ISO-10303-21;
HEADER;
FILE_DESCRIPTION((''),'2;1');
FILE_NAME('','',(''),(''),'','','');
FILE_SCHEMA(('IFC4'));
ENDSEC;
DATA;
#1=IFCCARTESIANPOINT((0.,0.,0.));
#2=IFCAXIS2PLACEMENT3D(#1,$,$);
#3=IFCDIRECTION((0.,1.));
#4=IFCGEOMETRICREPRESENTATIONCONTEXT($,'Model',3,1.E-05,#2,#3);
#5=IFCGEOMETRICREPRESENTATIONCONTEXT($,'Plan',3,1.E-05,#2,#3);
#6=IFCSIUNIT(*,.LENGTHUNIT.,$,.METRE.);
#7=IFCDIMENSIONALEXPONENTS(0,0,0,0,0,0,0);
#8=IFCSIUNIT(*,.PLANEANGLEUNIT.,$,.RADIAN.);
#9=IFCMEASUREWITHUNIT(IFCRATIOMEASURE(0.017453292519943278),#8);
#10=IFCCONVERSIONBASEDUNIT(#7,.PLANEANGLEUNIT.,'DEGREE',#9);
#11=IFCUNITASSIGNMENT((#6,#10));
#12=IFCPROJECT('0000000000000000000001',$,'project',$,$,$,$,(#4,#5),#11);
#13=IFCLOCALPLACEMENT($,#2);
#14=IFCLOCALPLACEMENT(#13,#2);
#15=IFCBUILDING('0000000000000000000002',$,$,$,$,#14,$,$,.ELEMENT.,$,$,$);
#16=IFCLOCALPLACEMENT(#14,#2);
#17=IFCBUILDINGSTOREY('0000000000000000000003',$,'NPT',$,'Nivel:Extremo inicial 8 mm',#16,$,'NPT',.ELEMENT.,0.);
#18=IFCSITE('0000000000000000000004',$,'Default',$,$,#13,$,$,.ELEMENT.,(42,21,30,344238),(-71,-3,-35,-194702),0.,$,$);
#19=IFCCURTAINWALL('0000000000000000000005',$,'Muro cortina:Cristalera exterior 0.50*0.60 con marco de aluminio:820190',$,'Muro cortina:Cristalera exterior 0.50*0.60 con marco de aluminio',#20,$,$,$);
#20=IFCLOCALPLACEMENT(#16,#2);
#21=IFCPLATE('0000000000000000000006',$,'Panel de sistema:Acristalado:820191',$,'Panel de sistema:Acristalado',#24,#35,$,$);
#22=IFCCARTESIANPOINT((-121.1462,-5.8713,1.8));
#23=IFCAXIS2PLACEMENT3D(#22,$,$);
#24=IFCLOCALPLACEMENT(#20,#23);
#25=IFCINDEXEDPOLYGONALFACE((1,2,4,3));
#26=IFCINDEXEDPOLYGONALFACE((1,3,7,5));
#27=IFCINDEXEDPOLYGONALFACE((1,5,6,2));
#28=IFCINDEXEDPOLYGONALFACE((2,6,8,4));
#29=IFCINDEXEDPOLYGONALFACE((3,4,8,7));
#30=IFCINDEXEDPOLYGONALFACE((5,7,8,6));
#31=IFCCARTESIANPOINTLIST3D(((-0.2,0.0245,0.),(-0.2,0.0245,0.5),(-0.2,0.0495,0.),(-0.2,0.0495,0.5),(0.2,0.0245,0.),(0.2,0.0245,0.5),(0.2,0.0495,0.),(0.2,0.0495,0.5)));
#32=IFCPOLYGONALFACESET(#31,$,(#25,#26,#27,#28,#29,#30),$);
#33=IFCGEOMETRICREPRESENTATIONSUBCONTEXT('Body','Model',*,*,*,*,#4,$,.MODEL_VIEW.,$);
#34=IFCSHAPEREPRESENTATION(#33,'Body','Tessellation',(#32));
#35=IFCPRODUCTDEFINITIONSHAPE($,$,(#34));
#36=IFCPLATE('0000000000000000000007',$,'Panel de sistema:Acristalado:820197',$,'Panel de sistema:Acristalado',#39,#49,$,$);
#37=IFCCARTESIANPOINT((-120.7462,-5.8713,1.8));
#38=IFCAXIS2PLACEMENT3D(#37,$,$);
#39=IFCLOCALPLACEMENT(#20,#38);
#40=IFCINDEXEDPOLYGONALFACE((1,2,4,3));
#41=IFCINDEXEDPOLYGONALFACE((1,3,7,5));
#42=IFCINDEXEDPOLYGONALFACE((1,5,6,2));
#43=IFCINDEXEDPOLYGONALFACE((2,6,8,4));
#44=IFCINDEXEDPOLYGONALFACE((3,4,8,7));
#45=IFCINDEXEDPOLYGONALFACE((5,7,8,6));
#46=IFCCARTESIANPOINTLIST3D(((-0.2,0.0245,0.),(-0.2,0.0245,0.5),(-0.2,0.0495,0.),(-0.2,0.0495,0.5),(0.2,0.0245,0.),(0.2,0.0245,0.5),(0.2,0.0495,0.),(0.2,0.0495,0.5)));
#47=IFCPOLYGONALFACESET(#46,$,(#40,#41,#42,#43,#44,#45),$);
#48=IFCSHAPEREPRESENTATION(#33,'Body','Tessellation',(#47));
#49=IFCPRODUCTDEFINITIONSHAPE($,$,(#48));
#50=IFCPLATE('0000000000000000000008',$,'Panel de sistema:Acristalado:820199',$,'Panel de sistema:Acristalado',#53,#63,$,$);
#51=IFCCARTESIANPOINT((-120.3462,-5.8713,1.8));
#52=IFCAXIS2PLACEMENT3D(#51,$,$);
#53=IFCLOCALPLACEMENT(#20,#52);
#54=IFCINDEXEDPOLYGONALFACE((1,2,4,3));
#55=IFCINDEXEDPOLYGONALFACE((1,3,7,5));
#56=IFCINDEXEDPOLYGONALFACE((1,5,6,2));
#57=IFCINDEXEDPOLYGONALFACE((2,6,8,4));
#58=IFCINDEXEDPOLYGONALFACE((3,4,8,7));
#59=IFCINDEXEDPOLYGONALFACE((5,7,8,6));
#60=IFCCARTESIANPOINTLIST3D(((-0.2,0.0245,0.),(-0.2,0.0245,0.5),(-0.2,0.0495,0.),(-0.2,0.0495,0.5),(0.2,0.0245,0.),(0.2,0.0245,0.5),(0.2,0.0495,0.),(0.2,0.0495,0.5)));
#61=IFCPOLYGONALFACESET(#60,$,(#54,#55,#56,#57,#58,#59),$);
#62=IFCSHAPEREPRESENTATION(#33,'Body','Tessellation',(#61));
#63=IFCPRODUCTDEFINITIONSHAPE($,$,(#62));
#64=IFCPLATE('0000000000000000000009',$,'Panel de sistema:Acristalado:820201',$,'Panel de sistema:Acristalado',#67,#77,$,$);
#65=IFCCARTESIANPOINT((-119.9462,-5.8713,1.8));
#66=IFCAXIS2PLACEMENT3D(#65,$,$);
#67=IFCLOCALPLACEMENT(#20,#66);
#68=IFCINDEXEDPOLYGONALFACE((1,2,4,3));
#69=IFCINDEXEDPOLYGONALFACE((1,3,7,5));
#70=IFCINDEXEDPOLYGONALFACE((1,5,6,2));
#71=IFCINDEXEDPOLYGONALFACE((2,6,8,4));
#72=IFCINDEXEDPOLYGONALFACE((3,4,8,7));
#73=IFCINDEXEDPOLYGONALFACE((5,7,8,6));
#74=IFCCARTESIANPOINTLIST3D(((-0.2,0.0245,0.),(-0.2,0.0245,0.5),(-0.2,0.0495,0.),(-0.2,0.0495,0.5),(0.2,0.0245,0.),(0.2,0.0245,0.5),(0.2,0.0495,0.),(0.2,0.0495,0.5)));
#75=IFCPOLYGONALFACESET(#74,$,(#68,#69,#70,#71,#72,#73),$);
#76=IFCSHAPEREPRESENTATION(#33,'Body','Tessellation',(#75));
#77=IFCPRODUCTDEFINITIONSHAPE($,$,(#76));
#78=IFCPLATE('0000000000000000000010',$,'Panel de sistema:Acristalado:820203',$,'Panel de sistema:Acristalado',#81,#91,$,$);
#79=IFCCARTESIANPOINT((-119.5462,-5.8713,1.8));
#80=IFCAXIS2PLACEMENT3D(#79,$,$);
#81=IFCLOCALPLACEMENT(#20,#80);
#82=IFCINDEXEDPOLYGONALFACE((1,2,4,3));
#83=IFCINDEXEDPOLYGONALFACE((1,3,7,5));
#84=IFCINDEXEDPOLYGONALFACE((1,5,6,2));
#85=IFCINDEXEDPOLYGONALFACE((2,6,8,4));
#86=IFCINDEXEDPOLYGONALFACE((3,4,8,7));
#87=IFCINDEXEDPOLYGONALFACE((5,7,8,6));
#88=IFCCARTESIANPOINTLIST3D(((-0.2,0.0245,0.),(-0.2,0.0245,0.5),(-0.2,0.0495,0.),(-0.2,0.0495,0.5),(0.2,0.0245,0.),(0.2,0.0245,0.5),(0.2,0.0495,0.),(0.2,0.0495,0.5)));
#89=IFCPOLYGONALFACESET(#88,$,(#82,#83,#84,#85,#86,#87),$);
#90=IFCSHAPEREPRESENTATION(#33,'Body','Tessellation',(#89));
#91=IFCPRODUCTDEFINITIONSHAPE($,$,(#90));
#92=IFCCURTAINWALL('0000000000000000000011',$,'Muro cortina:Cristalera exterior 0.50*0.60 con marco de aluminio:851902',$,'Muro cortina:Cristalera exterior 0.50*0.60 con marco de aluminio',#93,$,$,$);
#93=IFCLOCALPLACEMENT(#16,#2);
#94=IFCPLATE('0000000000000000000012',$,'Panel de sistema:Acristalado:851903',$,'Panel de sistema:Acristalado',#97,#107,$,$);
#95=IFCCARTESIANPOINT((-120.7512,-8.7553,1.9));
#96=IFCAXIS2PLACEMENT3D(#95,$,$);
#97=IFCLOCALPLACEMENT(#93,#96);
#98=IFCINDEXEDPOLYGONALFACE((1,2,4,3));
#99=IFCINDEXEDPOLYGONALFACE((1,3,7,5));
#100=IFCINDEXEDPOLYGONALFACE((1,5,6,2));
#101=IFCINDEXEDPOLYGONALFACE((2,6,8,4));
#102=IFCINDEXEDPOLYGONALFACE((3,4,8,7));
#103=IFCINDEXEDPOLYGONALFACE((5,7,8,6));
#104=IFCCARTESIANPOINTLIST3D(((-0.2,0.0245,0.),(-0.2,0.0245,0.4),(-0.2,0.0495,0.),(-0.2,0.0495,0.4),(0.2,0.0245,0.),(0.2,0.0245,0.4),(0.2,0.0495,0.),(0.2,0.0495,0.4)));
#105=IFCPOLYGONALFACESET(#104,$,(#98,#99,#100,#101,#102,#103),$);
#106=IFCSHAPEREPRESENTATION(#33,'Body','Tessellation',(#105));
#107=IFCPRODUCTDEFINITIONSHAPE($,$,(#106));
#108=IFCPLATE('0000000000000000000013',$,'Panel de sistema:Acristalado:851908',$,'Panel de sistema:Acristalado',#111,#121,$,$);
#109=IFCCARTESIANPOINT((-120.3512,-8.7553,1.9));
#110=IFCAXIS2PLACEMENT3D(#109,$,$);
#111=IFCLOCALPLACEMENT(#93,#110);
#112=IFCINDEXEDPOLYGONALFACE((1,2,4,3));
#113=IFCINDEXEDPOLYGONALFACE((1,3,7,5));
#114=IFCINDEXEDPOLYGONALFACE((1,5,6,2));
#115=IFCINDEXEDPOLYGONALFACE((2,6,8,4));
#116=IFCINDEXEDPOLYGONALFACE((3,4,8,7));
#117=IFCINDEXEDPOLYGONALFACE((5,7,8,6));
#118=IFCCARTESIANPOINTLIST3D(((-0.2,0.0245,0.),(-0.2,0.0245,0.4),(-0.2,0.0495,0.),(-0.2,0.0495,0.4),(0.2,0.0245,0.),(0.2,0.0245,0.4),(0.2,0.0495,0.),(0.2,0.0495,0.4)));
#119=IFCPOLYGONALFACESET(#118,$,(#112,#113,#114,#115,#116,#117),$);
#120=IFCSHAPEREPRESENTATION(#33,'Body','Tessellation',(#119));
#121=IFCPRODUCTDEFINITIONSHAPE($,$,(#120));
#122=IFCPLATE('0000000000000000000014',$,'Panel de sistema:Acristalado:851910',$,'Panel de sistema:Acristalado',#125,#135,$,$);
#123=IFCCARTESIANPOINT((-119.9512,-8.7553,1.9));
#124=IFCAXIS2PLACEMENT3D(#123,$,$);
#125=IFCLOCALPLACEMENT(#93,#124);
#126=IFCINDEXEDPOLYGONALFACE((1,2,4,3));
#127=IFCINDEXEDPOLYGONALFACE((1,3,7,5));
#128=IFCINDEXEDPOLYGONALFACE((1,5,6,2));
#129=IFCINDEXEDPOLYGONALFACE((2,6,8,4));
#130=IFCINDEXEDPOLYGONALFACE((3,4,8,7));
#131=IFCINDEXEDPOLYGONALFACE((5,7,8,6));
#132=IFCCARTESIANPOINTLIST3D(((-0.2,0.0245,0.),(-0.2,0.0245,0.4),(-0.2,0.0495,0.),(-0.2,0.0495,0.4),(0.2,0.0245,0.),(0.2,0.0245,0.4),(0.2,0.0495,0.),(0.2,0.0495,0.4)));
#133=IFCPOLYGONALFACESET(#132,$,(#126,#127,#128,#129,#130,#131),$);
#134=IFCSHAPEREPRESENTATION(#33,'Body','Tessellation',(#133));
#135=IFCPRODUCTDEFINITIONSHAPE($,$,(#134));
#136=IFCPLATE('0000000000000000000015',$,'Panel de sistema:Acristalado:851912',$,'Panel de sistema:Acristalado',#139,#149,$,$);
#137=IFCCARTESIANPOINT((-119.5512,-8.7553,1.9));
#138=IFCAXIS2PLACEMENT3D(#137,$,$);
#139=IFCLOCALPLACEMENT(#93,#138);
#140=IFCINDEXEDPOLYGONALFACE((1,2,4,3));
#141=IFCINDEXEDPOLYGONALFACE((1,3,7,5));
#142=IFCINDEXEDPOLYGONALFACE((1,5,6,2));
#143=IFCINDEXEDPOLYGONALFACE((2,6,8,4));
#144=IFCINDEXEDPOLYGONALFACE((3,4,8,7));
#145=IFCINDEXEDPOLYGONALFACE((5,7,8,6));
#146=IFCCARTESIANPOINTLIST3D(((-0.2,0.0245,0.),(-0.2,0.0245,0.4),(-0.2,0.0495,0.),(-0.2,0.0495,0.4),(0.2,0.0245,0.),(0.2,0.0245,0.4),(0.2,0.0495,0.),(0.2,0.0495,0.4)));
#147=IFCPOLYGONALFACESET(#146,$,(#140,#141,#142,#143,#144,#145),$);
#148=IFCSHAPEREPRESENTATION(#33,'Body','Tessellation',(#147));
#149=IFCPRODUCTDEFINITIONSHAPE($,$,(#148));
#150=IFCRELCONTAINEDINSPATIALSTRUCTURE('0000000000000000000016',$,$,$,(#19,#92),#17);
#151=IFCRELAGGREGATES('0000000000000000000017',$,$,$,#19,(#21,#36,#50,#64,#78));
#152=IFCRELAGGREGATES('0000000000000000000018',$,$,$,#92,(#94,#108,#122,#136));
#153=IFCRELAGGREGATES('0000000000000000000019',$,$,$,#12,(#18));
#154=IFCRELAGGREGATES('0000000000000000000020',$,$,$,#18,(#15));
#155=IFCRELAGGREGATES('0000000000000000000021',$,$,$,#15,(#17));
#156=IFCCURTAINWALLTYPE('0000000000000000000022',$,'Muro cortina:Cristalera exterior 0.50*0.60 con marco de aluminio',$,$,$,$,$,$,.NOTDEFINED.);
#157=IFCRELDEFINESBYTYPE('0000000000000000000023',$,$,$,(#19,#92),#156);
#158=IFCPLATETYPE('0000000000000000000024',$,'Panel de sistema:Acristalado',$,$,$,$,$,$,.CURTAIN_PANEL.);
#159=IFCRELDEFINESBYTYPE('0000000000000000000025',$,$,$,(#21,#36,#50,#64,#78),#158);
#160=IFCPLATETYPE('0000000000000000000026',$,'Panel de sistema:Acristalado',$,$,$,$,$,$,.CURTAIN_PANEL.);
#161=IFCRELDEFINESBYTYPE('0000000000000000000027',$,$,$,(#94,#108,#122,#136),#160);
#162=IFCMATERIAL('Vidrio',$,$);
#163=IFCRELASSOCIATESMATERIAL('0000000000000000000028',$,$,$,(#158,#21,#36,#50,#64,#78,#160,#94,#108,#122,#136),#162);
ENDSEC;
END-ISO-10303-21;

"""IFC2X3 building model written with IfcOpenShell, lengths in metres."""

from ifc_helpers import new_model, entity, si_unit, converted_unit, direction, frame, origin, origin_2d_with_axis, place, context, subcontext, project, spatial, rectangle, extrude, source, transform, mapped, material, type_object, type_shapes, element, aggregate, save


model = new_model("IFC2X3")

# Units and contexts
model_context = context("Model", 3, precision=1e-05, world=origin(), true_north=direction((0.0, 1.0)))
plan_context = context("Plan", 3, precision=1e-05, world=origin(), true_north=direction((0.0, 1.0)))
body_context = subcontext(model_context, "Body", "Model", "MODEL_VIEW")
ifc_project = project(units=[si_unit("LENGTHUNIT", "METRE"), converted_unit("PLANEANGLEUNIT", "DEGREE", entity("IfcRatioMeasure", 0.017453292519943278), si_unit("PLANEANGLEUNIT", "RADIAN"), dimensions=[0, 0, 0, 0, 0, 0, 0])], contexts=[model_context, plan_context])

# Site, building, storey
site_placement = place(None, origin())
site = spatial("IfcSite", under=ifc_project, at=site_placement, Name="Default", CompositionType="ELEMENT", RefLatitude=(42, 21, 30, 344238), RefLongitude=(-71, -3, -35, -194702), RefElevation=0.0)
building_placement = place(site_placement, origin())
building = spatial("IfcBuilding", under=site, at=building_placement, CompositionType="ELEMENT")
storey_placement = place(building_placement, origin())
storey = spatial("IfcBuildingStorey", under=building, at=storey_placement, Name="NPT", ObjectType="Nivel:Extremo inicial 8 mm", LongName="NPT", CompositionType="ELEMENT", Elevation=0.0)

# Curtain walls, plates
curtain_wall_type = type_object("IfcCurtainWallType", Name="Muro cortina:Cristalera exterior 0.50*0.60 con marco de aluminio", PredefinedType="NOTDEFINED")
curtain_wall_1_placement = place(storey_placement, origin())
curtain_wall_1 = element("IfcCurtainWall", 1, at=curtain_wall_1_placement, inside=storey, type_object=curtain_wall_type, Name="Muro cortina:Cristalera exterior 0.50*0.60 con marco de aluminio:820190", ObjectType="Muro cortina:Cristalera exterior 0.50*0.60 con marco de aluminio")
ifc_material_1 = material(Name="Vidrio")
plate_type_1 = type_object("IfcPlateType", Name="Panel de sistema:Acristalado", PredefinedType="CURTAIN_PANEL", material=ifc_material_1)
shared_shape_1 = source(origin(), body_context, "Body", "SweptSolid", [
    extrude(rectangle(XDim=0.025, YDim=0.4, at=origin_2d_with_axis()), frame((0.0, 0.037, 0.0), z_axis=(0.0, 0.0, 1.0), x_axis=(0.0, 1.0, 0.0)), (0.0, 0.0, 1.0), 0.5),
])
type_shapes(plate_type_1, [shared_shape_1])
plate_1_placement = place(curtain_wall_1_placement, frame((-121.1462, -5.8713, 1.8)))
plate_1 = element("IfcPlate", 2, at=plate_1_placement, type_object=plate_type_1, material=ifc_material_1, Name="Panel de sistema:Acristalado:820191", ObjectType="Panel de sistema:Acristalado", context=body_context, shape_type="MappedRepresentation", body=[
    mapped(shared_shape_1, transform((0.0, 0.0, 0.0), scale=1.0)),
])
plate_2_placement = place(curtain_wall_1_placement, frame((-120.7462, -5.8713, 1.8)))
plate_2 = element("IfcPlate", 3, at=plate_2_placement, type_object=plate_type_1, material=ifc_material_1, Name="Panel de sistema:Acristalado:820197", ObjectType="Panel de sistema:Acristalado", context=body_context, shape_type="MappedRepresentation", body=[
    mapped(shared_shape_1, transform((0.0, 0.0, 0.0), scale=1.0)),
])
plate_3_placement = place(curtain_wall_1_placement, frame((-120.3462, -5.8713, 1.8)))
plate_3 = element("IfcPlate", 4, at=plate_3_placement, type_object=plate_type_1, material=ifc_material_1, Name="Panel de sistema:Acristalado:820199", ObjectType="Panel de sistema:Acristalado", context=body_context, shape_type="MappedRepresentation", body=[
    mapped(shared_shape_1, transform((0.0, 0.0, 0.0), scale=1.0)),
])
plate_4_placement = place(curtain_wall_1_placement, frame((-119.9462, -5.8713, 1.8)))
plate_4 = element("IfcPlate", 5, at=plate_4_placement, type_object=plate_type_1, material=ifc_material_1, Name="Panel de sistema:Acristalado:820201", ObjectType="Panel de sistema:Acristalado", context=body_context, shape_type="MappedRepresentation", body=[
    mapped(shared_shape_1, transform((0.0, 0.0, 0.0), scale=1.0)),
])
plate_5_placement = place(curtain_wall_1_placement, frame((-119.5462, -5.8713, 1.8)))
plate_5 = element("IfcPlate", 6, at=plate_5_placement, type_object=plate_type_1, material=ifc_material_1, Name="Panel de sistema:Acristalado:820203", ObjectType="Panel de sistema:Acristalado", context=body_context, shape_type="MappedRepresentation", body=[
    mapped(shared_shape_1, transform((0.0, 0.0, 0.0), scale=1.0)),
])
aggregate(curtain_wall_1, [plate_1, plate_2, plate_3, plate_4, plate_5])
curtain_wall_2_placement = place(storey_placement, origin())
curtain_wall_2 = element("IfcCurtainWall", 7, at=curtain_wall_2_placement, inside=storey, type_object=curtain_wall_type, Name="Muro cortina:Cristalera exterior 0.50*0.60 con marco de aluminio:851902", ObjectType="Muro cortina:Cristalera exterior 0.50*0.60 con marco de aluminio")
plate_type_2 = type_object("IfcPlateType", Name="Panel de sistema:Acristalado", PredefinedType="CURTAIN_PANEL", material=ifc_material_1)
shared_shape_2 = source(origin(), body_context, "Body", "SweptSolid", [
    extrude(rectangle(XDim=0.025, YDim=0.4, at=origin_2d_with_axis()), frame((0.0, 0.037, 0.0), z_axis=(0.0, 0.0, 1.0), x_axis=(0.0, 1.0, 0.0)), (0.0, 0.0, 1.0), 0.4),
])
type_shapes(plate_type_2, [shared_shape_2])
plate_6_placement = place(curtain_wall_2_placement, frame((-120.7512, -8.7553, 1.9)))
plate_6 = element("IfcPlate", 8, at=plate_6_placement, type_object=plate_type_2, material=ifc_material_1, Name="Panel de sistema:Acristalado:851903", ObjectType="Panel de sistema:Acristalado", context=body_context, shape_type="MappedRepresentation", body=[
    mapped(shared_shape_2, transform((0.0, 0.0, 0.0), scale=1.0)),
])
plate_7_placement = place(curtain_wall_2_placement, frame((-120.3512, -8.7553, 1.9)))
plate_7 = element("IfcPlate", 9, at=plate_7_placement, type_object=plate_type_2, material=ifc_material_1, Name="Panel de sistema:Acristalado:851908", ObjectType="Panel de sistema:Acristalado", context=body_context, shape_type="MappedRepresentation", body=[
    mapped(shared_shape_2, transform((0.0, 0.0, 0.0), scale=1.0)),
])
plate_8_placement = place(curtain_wall_2_placement, frame((-119.9512, -8.7553, 1.9)))
plate_8 = element("IfcPlate", 10, at=plate_8_placement, type_object=plate_type_2, material=ifc_material_1, Name="Panel de sistema:Acristalado:851910", ObjectType="Panel de sistema:Acristalado", context=body_context, shape_type="MappedRepresentation", body=[
    mapped(shared_shape_2, transform((0.0, 0.0, 0.0), scale=1.0)),
])
plate_9_placement = place(curtain_wall_2_placement, frame((-119.5512, -8.7553, 1.9)))
plate_9 = element("IfcPlate", 11, at=plate_9_placement, type_object=plate_type_2, material=ifc_material_1, Name="Panel de sistema:Acristalado:851912", ObjectType="Panel de sistema:Acristalado", context=body_context, shape_type="MappedRepresentation", body=[
    mapped(shared_shape_2, transform((0.0, 0.0, 0.0), scale=1.0)),
])
aggregate(curtain_wall_2, [plate_6, plate_7, plate_8, plate_9])

save(model, "model.ifc")
